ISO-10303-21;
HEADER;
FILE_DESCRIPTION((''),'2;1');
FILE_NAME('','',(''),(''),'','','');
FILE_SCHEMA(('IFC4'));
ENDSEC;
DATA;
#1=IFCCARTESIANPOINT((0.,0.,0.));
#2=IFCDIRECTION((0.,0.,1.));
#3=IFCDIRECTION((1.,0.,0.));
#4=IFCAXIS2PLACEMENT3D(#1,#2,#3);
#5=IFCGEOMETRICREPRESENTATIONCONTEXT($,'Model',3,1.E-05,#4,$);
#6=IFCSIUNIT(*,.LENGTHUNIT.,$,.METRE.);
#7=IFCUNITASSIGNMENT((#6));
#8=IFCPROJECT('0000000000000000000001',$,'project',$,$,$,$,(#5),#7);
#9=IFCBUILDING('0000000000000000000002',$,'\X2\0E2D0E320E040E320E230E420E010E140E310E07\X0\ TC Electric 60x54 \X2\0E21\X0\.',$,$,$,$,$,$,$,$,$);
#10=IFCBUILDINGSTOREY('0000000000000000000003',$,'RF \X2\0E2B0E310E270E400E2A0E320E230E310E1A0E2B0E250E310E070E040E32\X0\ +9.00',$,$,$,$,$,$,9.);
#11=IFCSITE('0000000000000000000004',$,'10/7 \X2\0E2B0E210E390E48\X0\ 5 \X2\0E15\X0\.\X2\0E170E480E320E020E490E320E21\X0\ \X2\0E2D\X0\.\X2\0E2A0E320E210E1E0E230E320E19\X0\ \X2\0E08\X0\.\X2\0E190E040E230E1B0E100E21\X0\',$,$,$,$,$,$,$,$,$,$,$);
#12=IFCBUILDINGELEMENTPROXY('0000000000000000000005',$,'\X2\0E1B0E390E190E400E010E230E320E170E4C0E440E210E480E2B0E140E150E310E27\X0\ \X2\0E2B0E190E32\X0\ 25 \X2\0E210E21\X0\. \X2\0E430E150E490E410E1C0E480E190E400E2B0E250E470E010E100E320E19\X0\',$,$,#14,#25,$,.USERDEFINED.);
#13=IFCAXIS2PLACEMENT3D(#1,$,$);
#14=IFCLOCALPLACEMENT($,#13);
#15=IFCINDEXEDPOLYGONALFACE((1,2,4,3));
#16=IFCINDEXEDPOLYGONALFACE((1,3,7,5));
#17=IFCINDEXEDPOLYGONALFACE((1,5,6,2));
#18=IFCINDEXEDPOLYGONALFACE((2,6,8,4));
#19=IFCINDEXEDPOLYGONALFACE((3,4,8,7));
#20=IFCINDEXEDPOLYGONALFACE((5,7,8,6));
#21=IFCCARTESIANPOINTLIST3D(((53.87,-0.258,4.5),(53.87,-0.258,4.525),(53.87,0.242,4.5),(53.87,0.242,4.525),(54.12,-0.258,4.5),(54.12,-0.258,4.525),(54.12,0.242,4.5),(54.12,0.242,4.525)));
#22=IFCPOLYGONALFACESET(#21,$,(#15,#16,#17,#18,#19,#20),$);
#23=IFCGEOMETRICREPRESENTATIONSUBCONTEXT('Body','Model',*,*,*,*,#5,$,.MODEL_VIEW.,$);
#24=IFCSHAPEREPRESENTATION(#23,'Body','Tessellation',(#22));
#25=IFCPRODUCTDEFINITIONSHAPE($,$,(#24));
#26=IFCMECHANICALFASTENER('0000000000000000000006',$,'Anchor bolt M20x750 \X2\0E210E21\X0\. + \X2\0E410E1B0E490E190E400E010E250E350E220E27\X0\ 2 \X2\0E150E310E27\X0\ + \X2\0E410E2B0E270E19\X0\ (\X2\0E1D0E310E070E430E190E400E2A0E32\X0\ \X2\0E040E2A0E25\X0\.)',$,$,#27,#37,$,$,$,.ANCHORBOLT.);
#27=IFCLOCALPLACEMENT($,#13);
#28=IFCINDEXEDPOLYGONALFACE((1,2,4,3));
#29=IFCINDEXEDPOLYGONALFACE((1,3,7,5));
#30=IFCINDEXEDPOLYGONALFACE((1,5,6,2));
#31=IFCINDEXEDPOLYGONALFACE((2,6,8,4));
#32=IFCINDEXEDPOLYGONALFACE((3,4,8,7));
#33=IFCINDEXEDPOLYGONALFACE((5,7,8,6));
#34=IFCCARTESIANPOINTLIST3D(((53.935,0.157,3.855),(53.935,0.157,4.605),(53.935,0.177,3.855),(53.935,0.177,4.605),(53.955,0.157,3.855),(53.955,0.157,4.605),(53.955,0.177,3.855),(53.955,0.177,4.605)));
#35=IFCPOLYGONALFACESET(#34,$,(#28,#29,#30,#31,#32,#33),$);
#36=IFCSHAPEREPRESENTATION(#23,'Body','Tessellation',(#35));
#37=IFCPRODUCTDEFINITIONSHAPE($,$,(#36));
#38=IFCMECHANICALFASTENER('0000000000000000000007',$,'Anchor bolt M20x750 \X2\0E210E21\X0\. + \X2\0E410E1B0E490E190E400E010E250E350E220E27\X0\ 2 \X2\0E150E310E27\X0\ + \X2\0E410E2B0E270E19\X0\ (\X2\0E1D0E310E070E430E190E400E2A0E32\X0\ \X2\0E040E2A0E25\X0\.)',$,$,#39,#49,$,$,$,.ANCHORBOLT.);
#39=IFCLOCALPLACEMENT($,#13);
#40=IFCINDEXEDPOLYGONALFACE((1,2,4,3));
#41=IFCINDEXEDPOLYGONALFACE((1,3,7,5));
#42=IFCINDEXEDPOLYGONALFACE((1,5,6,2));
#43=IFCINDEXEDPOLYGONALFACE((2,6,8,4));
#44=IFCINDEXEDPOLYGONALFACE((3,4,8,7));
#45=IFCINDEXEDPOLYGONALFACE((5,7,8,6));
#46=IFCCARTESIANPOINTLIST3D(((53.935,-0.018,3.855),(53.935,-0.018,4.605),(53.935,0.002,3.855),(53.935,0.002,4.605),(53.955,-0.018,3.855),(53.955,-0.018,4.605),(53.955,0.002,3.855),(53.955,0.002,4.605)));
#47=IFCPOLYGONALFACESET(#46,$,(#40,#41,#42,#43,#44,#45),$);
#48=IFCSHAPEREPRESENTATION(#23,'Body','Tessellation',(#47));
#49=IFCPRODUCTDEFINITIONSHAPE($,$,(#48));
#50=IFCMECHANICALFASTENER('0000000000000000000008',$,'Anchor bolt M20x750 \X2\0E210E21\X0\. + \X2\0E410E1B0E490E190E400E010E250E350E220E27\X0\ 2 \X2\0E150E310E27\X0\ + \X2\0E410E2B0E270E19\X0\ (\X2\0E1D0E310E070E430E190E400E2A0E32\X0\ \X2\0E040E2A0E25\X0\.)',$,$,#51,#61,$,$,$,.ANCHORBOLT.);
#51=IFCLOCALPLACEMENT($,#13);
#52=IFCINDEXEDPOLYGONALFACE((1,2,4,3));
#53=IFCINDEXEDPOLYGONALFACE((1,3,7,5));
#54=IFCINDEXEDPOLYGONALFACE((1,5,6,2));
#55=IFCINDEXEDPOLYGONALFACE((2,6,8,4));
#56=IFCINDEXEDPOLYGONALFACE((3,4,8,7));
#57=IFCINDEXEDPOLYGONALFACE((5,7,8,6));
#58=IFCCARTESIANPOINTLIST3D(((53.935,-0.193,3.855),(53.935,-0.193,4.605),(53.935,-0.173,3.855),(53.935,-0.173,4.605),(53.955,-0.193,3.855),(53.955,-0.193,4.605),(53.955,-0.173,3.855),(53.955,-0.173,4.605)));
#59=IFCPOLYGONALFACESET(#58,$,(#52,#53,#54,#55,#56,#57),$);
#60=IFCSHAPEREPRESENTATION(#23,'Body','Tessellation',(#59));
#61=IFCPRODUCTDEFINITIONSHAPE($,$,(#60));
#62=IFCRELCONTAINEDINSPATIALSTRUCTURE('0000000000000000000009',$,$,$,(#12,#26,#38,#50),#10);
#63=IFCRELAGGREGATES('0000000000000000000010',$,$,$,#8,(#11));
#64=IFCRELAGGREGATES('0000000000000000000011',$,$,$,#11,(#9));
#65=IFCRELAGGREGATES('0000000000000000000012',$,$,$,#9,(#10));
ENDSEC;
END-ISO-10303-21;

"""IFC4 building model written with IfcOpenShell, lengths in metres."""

from ifc_helpers import new_model, si_unit, frame, origin, origin_with_axes, origin_2d, place, context, subcontext, project, spatial, rectangle, extrude, element, save


model = new_model("IFC4")

# Units and contexts
model_context = context("Model", 3, precision=1e-05, world=origin_with_axes())
body_context = subcontext(model_context, "Body", "Model", "MODEL_VIEW")
ifc_project = project(units=[si_unit("LENGTHUNIT", "METRE")], contexts=[model_context])

# Site, building, storey
site = spatial("IfcSite", under=ifc_project, Name="10/7 หมู่ 5 ต.ท่าข้าม อ.สามพราน จ.นครปฐม")
building = spatial("IfcBuilding", under=site, Name="อาคารโกดัง TC Electric 60x54 ม.")
storey = spatial("IfcBuildingStorey", under=building, Name="RF หัวเสารับหลังคา +9.00", Elevation=9.0)

# Building element proxy
proxy_1_placement = place(None, frame((53.995, -0.008, 4.5), z_axis=(0.0, 0.0, 1.0), x_axis=(1.0, 0.0, 0.0)))
element("IfcBuildingElementProxy", 1, at=proxy_1_placement, inside=storey, Name="ปูนเกราท์ไม่หดตัว หนา 25 มม. ใต้แผ่นเหล็กฐาน", PredefinedType="USERDEFINED", context=body_context, shape_type="SweptSolid", body=[
    extrude(rectangle(XDim=0.25, YDim=0.5, at=origin_2d()), origin(), (0.0, 0.0, 1.0), 0.025),
])

# Mechanical fasteners
for number, where, z_axis, x_axis, name in (
    (2, (53.945, 0.167, 3.855), (0.0, 0.0, 1.0), (1.0, 0.0, 0.0), "Anchor bolt M20x750 มม. + แป้นเกลียว 2 ตัว + แหวน (ฝังในเสา คสล.)"),
    (3, (53.945, -0.008, 3.855), (0.0, 0.0, 1.0), (1.0, 0.0, 0.0), "Anchor bolt M20x750 มม. + แป้นเกลียว 2 ตัว + แหวน (ฝังในเสา คสล.)"),
    (4, (53.945, -0.183, 3.855), (0.0, 0.0, 1.0), (1.0, 0.0, 0.0), "Anchor bolt M20x750 มม. + แป้นเกลียว 2 ตัว + แหวน (ฝังในเสา คสล.)"),
):
    element("IfcMechanicalFastener", number, at=place(None, frame(where, z_axis=z_axis, x_axis=x_axis)), inside=storey, Name=name, PredefinedType="ANCHORBOLT", context=body_context, shape_type="SweptSolid", body=[
        extrude(rectangle(XDim=0.02, YDim=0.02, at=origin_2d()), origin(), (0.0, 0.0, 1.0), 0.75),
    ])

save(model, "model.ifc")
